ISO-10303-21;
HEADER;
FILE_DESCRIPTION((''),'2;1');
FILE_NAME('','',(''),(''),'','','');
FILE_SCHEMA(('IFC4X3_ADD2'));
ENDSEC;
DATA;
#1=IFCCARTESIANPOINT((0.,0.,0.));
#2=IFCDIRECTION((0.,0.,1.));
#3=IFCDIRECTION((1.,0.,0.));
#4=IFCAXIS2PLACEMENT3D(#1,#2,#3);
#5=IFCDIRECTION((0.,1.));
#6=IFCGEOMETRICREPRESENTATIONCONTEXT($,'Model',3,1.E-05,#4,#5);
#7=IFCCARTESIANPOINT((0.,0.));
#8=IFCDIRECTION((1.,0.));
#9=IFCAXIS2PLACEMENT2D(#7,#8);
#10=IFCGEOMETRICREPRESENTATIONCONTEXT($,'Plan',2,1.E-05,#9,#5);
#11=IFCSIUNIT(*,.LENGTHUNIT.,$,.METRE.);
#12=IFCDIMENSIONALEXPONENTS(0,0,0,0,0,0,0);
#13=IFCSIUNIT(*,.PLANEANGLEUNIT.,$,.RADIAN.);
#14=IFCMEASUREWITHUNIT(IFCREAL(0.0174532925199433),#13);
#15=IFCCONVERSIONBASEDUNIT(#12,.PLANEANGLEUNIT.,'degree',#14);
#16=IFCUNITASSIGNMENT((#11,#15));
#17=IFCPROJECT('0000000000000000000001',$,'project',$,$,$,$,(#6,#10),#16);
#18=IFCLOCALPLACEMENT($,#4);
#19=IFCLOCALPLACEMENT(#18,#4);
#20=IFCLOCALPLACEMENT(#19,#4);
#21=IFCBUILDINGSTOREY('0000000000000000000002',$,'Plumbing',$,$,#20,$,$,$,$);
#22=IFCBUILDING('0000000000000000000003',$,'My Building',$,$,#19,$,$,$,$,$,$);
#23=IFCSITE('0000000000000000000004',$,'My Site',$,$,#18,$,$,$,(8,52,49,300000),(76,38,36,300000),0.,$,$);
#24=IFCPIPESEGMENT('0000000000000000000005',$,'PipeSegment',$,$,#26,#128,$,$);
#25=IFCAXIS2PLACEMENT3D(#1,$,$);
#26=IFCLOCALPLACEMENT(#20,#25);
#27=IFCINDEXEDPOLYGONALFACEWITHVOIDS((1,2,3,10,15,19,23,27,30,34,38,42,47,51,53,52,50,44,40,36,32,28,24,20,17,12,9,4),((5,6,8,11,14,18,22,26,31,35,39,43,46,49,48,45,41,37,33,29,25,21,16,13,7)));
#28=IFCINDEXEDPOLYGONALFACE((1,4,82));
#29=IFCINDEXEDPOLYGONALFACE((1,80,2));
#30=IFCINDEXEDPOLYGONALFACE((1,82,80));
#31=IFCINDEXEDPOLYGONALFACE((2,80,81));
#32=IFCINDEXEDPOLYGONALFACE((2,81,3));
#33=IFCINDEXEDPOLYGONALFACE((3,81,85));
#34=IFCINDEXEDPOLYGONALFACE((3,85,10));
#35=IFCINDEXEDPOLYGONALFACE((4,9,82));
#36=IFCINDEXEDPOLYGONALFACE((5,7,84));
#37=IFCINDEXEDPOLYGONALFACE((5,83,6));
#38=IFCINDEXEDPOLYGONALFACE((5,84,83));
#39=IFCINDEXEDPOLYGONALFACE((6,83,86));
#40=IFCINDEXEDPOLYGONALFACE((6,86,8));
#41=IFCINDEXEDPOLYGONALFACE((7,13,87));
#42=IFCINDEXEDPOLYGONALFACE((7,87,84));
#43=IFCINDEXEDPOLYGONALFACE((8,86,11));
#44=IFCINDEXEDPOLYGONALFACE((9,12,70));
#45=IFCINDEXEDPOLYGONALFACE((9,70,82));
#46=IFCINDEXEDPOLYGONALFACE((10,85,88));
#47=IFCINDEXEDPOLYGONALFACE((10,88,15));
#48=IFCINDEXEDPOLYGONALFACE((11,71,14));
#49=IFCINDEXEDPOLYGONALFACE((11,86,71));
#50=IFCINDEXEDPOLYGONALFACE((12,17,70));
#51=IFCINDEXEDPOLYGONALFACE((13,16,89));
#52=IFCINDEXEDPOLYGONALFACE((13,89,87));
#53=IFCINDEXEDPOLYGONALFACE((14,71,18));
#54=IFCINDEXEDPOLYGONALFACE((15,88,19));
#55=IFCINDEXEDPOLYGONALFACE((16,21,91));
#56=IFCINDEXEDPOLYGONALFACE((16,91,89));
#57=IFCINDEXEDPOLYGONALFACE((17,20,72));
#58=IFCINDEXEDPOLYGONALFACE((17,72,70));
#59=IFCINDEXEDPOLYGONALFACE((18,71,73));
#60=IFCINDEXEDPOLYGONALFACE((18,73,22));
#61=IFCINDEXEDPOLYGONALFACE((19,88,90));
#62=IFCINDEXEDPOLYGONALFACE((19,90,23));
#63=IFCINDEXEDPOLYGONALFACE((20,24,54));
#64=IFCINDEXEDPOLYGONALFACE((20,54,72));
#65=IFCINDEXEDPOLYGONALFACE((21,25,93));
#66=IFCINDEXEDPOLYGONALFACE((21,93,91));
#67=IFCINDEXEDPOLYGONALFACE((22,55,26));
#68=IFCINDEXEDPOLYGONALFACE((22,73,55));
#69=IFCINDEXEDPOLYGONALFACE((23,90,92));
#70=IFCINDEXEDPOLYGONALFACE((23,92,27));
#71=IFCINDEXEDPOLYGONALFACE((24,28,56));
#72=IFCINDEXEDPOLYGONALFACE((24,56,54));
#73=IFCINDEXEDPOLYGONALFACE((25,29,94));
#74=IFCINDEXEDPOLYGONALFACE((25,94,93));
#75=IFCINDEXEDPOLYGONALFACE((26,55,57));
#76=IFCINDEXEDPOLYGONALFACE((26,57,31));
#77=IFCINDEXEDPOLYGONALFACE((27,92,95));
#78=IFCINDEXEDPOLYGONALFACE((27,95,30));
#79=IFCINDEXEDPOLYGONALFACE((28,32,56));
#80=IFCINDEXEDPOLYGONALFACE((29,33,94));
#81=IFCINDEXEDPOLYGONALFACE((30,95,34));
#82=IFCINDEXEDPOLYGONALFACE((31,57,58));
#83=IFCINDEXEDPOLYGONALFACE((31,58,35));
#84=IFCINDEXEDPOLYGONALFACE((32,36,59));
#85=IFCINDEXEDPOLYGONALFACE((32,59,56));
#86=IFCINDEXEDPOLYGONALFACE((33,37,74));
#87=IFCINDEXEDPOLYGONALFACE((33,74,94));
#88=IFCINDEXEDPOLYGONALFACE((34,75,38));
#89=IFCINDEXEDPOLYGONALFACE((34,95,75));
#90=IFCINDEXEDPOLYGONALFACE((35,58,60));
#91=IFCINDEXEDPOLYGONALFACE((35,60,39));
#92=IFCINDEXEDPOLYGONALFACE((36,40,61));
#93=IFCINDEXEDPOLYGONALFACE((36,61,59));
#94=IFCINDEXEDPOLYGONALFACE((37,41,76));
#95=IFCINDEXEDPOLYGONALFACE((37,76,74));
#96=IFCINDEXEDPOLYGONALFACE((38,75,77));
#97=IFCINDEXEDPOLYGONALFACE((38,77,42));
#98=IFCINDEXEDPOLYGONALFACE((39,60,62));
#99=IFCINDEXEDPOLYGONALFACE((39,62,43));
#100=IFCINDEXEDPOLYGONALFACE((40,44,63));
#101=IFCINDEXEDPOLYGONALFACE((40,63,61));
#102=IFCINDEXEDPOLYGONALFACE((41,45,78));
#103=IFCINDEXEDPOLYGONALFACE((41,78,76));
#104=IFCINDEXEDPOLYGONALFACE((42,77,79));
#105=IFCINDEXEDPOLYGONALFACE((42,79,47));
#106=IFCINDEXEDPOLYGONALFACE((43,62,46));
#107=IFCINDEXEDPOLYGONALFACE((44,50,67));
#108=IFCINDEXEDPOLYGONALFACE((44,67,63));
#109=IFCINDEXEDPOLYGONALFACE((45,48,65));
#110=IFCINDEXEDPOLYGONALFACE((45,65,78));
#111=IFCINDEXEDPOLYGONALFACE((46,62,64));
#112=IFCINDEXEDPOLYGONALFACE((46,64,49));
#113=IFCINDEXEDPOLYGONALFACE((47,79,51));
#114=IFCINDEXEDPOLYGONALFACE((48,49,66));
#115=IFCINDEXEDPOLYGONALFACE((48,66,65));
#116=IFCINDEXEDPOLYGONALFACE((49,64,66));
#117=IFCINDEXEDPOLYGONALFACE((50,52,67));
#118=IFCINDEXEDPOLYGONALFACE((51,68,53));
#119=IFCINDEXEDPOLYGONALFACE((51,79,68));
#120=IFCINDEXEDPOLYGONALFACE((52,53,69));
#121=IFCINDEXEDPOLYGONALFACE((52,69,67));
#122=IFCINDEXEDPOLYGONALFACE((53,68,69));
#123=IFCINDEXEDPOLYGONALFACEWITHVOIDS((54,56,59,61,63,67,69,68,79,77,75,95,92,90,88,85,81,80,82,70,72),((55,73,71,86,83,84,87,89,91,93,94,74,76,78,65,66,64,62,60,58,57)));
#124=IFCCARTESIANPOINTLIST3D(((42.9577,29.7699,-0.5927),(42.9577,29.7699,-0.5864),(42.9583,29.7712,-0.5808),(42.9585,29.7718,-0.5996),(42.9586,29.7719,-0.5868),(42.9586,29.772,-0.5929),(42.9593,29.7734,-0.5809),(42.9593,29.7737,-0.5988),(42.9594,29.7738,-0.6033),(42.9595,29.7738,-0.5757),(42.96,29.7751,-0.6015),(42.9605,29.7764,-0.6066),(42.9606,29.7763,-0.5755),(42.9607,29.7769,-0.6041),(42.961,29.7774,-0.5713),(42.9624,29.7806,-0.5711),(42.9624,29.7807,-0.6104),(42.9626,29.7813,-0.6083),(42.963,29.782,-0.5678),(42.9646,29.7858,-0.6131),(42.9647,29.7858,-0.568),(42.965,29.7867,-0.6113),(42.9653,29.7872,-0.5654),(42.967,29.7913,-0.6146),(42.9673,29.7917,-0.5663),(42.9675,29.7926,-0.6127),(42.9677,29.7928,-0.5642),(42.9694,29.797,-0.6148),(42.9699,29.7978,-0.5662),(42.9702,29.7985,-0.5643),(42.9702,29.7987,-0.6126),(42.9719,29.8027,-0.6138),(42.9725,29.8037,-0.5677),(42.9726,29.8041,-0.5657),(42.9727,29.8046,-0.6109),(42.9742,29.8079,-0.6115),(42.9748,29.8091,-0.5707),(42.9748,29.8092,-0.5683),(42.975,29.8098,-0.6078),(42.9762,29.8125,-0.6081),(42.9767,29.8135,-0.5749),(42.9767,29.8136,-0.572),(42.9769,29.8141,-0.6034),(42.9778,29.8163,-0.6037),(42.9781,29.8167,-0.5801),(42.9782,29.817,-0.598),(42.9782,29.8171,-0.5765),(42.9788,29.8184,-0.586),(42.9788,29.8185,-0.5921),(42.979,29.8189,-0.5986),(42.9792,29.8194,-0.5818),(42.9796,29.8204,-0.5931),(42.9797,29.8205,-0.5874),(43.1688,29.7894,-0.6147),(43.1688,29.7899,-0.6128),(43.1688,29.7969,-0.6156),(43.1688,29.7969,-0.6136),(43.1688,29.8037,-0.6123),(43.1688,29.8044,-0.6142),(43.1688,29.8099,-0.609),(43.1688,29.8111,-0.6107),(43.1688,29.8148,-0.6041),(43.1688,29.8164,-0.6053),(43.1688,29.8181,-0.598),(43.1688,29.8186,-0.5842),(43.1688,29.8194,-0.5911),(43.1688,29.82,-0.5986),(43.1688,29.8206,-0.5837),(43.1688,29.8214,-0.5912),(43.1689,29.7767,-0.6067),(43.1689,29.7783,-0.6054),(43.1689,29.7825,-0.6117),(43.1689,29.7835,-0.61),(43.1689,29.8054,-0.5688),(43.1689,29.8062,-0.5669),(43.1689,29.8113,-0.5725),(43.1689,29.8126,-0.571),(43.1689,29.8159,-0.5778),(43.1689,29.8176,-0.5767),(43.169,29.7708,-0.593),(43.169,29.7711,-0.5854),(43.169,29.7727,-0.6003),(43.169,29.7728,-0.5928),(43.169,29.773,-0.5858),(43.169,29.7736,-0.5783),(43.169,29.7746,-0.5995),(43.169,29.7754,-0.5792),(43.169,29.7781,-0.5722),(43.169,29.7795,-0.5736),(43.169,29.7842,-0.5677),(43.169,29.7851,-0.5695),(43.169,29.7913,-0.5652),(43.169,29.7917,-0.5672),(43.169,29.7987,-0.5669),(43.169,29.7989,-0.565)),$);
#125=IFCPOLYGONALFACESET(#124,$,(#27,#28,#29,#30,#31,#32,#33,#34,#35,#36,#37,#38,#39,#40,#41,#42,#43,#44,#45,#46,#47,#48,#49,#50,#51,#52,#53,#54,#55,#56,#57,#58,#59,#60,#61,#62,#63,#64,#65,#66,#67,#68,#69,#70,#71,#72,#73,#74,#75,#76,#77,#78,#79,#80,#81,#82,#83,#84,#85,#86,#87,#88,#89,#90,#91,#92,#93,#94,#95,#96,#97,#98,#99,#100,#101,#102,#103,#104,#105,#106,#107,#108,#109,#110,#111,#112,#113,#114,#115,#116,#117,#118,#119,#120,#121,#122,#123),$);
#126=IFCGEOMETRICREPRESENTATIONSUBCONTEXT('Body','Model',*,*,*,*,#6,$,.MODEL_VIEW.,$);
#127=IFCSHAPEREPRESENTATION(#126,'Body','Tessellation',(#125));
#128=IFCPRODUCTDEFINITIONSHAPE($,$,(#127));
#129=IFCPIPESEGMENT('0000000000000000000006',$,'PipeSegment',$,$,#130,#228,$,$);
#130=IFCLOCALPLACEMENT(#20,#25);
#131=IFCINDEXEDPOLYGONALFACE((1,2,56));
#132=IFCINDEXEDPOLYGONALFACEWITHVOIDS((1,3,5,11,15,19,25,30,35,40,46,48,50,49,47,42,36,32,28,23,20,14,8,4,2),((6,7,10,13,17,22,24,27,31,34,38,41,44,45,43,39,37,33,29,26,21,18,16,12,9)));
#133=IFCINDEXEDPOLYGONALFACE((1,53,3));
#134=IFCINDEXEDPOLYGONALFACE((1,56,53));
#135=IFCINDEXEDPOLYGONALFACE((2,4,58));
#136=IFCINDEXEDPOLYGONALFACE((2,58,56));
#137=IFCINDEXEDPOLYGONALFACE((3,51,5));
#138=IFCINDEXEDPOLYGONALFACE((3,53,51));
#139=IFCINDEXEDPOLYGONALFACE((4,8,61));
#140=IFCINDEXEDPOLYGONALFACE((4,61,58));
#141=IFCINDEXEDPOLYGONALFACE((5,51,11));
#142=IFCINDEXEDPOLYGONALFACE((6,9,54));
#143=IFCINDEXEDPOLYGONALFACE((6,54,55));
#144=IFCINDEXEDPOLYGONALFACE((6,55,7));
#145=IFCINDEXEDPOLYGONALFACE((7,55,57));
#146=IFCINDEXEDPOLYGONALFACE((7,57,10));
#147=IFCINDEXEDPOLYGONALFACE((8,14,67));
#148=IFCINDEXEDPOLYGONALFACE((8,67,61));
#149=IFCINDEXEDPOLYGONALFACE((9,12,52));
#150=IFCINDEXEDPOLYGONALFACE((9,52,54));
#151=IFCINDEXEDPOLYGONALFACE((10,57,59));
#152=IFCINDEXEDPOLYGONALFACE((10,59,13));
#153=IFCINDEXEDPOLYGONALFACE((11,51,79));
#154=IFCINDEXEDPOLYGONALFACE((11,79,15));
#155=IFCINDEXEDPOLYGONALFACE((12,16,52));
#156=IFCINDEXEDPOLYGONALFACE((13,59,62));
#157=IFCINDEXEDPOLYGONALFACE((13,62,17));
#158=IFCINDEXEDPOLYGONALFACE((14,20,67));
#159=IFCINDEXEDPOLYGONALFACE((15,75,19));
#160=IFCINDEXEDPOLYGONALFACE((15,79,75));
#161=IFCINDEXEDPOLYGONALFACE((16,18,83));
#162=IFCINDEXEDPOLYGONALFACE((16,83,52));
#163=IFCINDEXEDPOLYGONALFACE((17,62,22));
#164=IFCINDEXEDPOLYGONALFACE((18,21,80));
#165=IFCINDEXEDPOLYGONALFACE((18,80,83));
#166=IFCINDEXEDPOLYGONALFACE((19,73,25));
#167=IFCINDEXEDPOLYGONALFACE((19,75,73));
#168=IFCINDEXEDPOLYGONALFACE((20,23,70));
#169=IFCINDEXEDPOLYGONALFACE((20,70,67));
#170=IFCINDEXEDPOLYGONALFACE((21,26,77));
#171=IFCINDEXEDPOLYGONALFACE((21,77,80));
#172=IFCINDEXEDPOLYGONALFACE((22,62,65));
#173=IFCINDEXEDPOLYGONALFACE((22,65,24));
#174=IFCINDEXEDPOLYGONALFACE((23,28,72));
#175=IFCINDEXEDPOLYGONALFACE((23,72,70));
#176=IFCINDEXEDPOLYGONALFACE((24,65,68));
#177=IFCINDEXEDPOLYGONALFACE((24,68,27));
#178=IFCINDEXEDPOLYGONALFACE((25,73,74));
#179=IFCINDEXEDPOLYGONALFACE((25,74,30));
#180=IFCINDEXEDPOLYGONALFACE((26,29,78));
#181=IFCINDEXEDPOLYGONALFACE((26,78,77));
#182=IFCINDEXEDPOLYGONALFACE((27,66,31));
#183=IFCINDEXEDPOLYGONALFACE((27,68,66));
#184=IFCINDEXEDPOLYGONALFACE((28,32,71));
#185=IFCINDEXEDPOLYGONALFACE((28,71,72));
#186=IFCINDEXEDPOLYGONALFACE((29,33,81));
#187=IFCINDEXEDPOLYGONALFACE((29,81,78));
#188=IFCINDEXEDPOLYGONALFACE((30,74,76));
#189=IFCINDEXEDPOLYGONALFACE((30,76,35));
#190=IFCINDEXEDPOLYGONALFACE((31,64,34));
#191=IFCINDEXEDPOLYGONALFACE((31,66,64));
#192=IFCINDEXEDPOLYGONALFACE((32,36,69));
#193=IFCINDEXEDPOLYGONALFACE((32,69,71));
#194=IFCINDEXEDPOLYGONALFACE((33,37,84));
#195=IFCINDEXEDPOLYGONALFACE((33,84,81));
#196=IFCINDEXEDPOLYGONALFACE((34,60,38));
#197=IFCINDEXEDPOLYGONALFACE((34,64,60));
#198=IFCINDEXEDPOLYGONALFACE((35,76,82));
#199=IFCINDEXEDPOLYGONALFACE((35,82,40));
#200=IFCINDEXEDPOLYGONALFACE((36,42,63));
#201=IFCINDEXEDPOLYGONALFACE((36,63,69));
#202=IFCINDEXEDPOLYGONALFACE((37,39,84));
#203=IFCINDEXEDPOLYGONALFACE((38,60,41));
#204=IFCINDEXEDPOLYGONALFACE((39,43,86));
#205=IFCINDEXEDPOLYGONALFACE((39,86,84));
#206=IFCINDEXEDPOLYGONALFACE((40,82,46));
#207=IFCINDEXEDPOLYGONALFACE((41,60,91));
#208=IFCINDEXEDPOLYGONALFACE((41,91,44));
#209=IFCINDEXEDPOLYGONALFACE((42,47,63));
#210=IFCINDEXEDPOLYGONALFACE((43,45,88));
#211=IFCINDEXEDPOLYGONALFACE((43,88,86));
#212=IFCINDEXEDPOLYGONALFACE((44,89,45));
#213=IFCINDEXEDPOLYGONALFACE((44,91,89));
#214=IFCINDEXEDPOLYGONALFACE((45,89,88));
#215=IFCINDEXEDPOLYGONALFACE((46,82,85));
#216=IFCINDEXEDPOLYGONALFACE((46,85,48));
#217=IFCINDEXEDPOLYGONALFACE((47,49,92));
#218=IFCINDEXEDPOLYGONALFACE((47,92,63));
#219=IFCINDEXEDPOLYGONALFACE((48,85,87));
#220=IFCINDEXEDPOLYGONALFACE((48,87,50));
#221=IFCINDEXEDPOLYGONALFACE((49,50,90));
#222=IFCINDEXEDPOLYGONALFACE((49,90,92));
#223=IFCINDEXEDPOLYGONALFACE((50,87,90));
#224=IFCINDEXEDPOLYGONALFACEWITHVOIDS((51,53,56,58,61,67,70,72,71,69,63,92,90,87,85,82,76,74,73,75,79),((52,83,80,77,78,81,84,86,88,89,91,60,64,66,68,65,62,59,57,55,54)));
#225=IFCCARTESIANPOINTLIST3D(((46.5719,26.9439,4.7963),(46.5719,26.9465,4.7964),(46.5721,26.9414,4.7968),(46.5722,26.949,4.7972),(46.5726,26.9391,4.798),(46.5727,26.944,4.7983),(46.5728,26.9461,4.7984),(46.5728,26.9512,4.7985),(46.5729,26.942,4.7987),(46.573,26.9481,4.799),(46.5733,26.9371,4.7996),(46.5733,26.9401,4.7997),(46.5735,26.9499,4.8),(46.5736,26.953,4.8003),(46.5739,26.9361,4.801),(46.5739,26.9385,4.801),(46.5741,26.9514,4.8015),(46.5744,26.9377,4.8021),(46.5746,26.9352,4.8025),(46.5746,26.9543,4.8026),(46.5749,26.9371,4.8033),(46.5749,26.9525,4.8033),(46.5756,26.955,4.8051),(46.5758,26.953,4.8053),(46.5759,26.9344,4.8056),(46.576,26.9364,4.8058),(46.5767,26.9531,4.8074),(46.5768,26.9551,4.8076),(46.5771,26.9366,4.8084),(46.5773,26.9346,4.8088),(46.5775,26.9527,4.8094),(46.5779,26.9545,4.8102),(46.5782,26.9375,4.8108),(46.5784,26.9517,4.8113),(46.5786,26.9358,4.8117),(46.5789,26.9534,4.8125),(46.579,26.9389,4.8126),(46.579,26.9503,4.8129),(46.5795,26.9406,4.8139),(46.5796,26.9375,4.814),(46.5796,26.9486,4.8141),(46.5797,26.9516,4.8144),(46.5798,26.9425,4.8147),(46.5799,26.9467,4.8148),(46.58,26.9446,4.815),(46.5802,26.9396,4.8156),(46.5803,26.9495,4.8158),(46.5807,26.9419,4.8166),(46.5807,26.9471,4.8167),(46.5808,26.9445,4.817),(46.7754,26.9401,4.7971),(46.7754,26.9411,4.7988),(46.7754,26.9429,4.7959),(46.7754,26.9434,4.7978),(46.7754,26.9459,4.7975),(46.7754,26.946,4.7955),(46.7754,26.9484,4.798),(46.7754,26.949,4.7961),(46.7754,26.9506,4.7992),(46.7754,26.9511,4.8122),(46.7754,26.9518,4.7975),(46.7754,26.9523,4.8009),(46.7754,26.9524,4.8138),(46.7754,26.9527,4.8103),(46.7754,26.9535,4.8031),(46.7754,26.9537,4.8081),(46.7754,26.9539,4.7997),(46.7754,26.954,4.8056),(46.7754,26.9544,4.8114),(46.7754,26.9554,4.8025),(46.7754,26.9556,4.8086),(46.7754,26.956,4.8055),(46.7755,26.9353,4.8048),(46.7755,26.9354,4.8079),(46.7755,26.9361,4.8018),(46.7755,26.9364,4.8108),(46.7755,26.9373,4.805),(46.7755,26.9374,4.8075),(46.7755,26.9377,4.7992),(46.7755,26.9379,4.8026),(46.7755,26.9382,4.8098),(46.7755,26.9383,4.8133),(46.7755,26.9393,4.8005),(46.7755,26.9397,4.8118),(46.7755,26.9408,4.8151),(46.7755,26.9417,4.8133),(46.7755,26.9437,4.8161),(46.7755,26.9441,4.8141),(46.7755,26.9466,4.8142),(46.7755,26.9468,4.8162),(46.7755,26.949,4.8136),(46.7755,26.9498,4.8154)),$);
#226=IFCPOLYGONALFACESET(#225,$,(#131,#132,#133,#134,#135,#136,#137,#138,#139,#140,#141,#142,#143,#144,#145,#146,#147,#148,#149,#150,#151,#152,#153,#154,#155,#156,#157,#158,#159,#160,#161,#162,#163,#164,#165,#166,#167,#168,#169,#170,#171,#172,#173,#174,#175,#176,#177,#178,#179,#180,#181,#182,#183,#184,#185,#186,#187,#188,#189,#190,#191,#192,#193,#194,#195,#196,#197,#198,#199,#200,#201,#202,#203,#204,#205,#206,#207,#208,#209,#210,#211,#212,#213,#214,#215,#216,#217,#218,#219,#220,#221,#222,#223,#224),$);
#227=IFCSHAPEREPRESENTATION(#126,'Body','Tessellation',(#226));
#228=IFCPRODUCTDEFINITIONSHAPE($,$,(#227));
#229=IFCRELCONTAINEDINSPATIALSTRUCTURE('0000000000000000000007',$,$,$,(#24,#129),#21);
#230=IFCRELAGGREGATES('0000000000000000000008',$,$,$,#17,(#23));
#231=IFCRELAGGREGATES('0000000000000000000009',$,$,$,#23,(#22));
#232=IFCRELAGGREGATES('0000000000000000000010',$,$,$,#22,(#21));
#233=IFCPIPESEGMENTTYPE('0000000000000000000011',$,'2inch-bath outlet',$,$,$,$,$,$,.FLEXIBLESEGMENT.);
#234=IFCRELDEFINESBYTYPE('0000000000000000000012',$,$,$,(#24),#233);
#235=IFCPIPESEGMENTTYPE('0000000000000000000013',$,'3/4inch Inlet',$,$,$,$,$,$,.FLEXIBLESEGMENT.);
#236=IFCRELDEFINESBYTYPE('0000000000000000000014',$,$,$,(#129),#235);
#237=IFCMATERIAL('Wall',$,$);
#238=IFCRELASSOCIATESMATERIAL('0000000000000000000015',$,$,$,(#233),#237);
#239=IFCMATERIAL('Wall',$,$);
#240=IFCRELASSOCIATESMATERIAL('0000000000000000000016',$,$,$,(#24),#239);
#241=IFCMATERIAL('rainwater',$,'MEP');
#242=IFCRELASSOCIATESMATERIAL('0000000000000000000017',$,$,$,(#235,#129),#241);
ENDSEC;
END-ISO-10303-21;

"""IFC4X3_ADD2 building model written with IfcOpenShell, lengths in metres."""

from ifc_helpers import new_model, entity, si_unit, converted_unit, direction, frame, origin_with_axes, origin_2d_with_axis, place, context, subcontext, project, spatial, hollow_circle, extrude, clip, halfspace, material, material_profile, profile_set, profile_usage, type_object, element, save


model = new_model("IFC4X3_ADD2")

# Units and contexts
model_context = context("Model", 3, precision=1e-05, world=origin_with_axes(), true_north=direction((0.0, 1.0)))
plan_context = context("Plan", 2, precision=1e-05, world=origin_2d_with_axis(), true_north=direction((0.0, 1.0)))
body_context = subcontext(model_context, "Body", "Model", "MODEL_VIEW")
ifc_project = project(units=[si_unit("LENGTHUNIT", "METRE"), converted_unit("PLANEANGLEUNIT", "degree", entity("IfcReal", 0.0174532925199433), si_unit("PLANEANGLEUNIT", "RADIAN"), dimensions=[0, 0, 0, 0, 0, 0, 0])], contexts=[model_context, plan_context])

# Site, building, storey
site_placement = place(None, origin_with_axes())
site = spatial("IfcSite", under=ifc_project, at=site_placement, Name="My Site", RefLatitude=(8, 52, 49, 300000), RefLongitude=(76, 38, 36, 300000), RefElevation=0.0)
building_placement = place(site_placement, origin_with_axes())
building = spatial("IfcBuilding", under=site, at=building_placement, Name="My Building")
storey_placement = place(building_placement, origin_with_axes())
storey = spatial("IfcBuildingStorey", under=building, at=storey_placement, Name="Plumbing")

# Pipe segments
ifc_material_1 = material(Name="Wall")
ifc_material_profile_1 = material_profile(ifc_material_1, hollow_circle(Radius=0.0254, WallThickness=0.002))
ifc_profile_set_1 = profile_set([ifc_material_profile_1], Name="graywater")
ifc_material_2 = material(Name="Wall")
ifc_material_profile_2 = material_profile(ifc_material_2, hollow_circle(Radius=0.0254, WallThickness=0.002))
ifc_profile_set_2 = profile_set([ifc_material_profile_2], Name="graywater")
pipe_segment_type_1 = type_object("IfcPipeSegmentType", Name="2inch-bath outlet", PredefinedType="FLEXIBLESEGMENT", material=ifc_profile_set_2)
ifc_profile_usage_1 = profile_usage(ifc_profile_set_1, cardinal=5)
pipe_segment_1_placement = place(storey_placement, frame((43.1689, 29.796, -0.5902), z_axis=(-0.999985, -0.004219, 0.003595), x_axis=(0.002438, -0.917305, -0.398179)))
element("IfcPipeSegment", 1, at=pipe_segment_1_placement, inside=storey, type_object=pipe_segment_type_1, material=ifc_profile_usage_1, Name="PipeSegment", context=body_context, shape_type="Clipping", body=[
    clip(extrude(hollow_circle(Radius=0.0254, WallThickness=0.002), origin_with_axes(), (0.0, 0.0, 1.0), 0.251), halfspace(frame((0.0403, -0.0678, 0.2045), z_axis=(-0.368459, -0.160869, 0.91562), x_axis=(-0.400126, 0.91646, 0.0)), False)),
])
ifc_material_3 = material(Name="rainwater", Category="MEP")
ifc_material_profile_3 = material_profile(ifc_material_3, hollow_circle(Radius=0.0104, WallThickness=0.002))
ifc_profile_set_3 = profile_set([ifc_material_profile_3], Name="water")
pipe_segment_type_2 = type_object("IfcPipeSegmentType", Name="3/4inch Inlet", PredefinedType="FLEXIBLESEGMENT", material=ifc_profile_set_3)
ifc_profile_usage_2 = profile_usage(ifc_profile_set_3, cardinal=5)
pipe_segment_2_placement = place(storey_placement, frame((46.7754, 26.9456, 4.8059), z_axis=(-0.999985, -0.004219, 0.003595), x_axis=(0.002438, -0.917305, -0.398179)))
element("IfcPipeSegment", 2, at=pipe_segment_2_placement, inside=storey, type_object=pipe_segment_type_2, material=ifc_profile_usage_2, Name="PipeSegment", context=body_context, shape_type="Clipping", body=[
    clip(extrude(hollow_circle(Radius=0.0104, WallThickness=0.002), origin_with_axes(), (0.0, 0.0, 1.0), 0.2199), halfspace(frame((-0.0315, -0.0074, 0.1966), z_axis=(-0.158546, 0.361655, 0.918732), x_axis=(0.915857, 0.401504, 0.0)), False)),
])

save(model, "model.ifc")
